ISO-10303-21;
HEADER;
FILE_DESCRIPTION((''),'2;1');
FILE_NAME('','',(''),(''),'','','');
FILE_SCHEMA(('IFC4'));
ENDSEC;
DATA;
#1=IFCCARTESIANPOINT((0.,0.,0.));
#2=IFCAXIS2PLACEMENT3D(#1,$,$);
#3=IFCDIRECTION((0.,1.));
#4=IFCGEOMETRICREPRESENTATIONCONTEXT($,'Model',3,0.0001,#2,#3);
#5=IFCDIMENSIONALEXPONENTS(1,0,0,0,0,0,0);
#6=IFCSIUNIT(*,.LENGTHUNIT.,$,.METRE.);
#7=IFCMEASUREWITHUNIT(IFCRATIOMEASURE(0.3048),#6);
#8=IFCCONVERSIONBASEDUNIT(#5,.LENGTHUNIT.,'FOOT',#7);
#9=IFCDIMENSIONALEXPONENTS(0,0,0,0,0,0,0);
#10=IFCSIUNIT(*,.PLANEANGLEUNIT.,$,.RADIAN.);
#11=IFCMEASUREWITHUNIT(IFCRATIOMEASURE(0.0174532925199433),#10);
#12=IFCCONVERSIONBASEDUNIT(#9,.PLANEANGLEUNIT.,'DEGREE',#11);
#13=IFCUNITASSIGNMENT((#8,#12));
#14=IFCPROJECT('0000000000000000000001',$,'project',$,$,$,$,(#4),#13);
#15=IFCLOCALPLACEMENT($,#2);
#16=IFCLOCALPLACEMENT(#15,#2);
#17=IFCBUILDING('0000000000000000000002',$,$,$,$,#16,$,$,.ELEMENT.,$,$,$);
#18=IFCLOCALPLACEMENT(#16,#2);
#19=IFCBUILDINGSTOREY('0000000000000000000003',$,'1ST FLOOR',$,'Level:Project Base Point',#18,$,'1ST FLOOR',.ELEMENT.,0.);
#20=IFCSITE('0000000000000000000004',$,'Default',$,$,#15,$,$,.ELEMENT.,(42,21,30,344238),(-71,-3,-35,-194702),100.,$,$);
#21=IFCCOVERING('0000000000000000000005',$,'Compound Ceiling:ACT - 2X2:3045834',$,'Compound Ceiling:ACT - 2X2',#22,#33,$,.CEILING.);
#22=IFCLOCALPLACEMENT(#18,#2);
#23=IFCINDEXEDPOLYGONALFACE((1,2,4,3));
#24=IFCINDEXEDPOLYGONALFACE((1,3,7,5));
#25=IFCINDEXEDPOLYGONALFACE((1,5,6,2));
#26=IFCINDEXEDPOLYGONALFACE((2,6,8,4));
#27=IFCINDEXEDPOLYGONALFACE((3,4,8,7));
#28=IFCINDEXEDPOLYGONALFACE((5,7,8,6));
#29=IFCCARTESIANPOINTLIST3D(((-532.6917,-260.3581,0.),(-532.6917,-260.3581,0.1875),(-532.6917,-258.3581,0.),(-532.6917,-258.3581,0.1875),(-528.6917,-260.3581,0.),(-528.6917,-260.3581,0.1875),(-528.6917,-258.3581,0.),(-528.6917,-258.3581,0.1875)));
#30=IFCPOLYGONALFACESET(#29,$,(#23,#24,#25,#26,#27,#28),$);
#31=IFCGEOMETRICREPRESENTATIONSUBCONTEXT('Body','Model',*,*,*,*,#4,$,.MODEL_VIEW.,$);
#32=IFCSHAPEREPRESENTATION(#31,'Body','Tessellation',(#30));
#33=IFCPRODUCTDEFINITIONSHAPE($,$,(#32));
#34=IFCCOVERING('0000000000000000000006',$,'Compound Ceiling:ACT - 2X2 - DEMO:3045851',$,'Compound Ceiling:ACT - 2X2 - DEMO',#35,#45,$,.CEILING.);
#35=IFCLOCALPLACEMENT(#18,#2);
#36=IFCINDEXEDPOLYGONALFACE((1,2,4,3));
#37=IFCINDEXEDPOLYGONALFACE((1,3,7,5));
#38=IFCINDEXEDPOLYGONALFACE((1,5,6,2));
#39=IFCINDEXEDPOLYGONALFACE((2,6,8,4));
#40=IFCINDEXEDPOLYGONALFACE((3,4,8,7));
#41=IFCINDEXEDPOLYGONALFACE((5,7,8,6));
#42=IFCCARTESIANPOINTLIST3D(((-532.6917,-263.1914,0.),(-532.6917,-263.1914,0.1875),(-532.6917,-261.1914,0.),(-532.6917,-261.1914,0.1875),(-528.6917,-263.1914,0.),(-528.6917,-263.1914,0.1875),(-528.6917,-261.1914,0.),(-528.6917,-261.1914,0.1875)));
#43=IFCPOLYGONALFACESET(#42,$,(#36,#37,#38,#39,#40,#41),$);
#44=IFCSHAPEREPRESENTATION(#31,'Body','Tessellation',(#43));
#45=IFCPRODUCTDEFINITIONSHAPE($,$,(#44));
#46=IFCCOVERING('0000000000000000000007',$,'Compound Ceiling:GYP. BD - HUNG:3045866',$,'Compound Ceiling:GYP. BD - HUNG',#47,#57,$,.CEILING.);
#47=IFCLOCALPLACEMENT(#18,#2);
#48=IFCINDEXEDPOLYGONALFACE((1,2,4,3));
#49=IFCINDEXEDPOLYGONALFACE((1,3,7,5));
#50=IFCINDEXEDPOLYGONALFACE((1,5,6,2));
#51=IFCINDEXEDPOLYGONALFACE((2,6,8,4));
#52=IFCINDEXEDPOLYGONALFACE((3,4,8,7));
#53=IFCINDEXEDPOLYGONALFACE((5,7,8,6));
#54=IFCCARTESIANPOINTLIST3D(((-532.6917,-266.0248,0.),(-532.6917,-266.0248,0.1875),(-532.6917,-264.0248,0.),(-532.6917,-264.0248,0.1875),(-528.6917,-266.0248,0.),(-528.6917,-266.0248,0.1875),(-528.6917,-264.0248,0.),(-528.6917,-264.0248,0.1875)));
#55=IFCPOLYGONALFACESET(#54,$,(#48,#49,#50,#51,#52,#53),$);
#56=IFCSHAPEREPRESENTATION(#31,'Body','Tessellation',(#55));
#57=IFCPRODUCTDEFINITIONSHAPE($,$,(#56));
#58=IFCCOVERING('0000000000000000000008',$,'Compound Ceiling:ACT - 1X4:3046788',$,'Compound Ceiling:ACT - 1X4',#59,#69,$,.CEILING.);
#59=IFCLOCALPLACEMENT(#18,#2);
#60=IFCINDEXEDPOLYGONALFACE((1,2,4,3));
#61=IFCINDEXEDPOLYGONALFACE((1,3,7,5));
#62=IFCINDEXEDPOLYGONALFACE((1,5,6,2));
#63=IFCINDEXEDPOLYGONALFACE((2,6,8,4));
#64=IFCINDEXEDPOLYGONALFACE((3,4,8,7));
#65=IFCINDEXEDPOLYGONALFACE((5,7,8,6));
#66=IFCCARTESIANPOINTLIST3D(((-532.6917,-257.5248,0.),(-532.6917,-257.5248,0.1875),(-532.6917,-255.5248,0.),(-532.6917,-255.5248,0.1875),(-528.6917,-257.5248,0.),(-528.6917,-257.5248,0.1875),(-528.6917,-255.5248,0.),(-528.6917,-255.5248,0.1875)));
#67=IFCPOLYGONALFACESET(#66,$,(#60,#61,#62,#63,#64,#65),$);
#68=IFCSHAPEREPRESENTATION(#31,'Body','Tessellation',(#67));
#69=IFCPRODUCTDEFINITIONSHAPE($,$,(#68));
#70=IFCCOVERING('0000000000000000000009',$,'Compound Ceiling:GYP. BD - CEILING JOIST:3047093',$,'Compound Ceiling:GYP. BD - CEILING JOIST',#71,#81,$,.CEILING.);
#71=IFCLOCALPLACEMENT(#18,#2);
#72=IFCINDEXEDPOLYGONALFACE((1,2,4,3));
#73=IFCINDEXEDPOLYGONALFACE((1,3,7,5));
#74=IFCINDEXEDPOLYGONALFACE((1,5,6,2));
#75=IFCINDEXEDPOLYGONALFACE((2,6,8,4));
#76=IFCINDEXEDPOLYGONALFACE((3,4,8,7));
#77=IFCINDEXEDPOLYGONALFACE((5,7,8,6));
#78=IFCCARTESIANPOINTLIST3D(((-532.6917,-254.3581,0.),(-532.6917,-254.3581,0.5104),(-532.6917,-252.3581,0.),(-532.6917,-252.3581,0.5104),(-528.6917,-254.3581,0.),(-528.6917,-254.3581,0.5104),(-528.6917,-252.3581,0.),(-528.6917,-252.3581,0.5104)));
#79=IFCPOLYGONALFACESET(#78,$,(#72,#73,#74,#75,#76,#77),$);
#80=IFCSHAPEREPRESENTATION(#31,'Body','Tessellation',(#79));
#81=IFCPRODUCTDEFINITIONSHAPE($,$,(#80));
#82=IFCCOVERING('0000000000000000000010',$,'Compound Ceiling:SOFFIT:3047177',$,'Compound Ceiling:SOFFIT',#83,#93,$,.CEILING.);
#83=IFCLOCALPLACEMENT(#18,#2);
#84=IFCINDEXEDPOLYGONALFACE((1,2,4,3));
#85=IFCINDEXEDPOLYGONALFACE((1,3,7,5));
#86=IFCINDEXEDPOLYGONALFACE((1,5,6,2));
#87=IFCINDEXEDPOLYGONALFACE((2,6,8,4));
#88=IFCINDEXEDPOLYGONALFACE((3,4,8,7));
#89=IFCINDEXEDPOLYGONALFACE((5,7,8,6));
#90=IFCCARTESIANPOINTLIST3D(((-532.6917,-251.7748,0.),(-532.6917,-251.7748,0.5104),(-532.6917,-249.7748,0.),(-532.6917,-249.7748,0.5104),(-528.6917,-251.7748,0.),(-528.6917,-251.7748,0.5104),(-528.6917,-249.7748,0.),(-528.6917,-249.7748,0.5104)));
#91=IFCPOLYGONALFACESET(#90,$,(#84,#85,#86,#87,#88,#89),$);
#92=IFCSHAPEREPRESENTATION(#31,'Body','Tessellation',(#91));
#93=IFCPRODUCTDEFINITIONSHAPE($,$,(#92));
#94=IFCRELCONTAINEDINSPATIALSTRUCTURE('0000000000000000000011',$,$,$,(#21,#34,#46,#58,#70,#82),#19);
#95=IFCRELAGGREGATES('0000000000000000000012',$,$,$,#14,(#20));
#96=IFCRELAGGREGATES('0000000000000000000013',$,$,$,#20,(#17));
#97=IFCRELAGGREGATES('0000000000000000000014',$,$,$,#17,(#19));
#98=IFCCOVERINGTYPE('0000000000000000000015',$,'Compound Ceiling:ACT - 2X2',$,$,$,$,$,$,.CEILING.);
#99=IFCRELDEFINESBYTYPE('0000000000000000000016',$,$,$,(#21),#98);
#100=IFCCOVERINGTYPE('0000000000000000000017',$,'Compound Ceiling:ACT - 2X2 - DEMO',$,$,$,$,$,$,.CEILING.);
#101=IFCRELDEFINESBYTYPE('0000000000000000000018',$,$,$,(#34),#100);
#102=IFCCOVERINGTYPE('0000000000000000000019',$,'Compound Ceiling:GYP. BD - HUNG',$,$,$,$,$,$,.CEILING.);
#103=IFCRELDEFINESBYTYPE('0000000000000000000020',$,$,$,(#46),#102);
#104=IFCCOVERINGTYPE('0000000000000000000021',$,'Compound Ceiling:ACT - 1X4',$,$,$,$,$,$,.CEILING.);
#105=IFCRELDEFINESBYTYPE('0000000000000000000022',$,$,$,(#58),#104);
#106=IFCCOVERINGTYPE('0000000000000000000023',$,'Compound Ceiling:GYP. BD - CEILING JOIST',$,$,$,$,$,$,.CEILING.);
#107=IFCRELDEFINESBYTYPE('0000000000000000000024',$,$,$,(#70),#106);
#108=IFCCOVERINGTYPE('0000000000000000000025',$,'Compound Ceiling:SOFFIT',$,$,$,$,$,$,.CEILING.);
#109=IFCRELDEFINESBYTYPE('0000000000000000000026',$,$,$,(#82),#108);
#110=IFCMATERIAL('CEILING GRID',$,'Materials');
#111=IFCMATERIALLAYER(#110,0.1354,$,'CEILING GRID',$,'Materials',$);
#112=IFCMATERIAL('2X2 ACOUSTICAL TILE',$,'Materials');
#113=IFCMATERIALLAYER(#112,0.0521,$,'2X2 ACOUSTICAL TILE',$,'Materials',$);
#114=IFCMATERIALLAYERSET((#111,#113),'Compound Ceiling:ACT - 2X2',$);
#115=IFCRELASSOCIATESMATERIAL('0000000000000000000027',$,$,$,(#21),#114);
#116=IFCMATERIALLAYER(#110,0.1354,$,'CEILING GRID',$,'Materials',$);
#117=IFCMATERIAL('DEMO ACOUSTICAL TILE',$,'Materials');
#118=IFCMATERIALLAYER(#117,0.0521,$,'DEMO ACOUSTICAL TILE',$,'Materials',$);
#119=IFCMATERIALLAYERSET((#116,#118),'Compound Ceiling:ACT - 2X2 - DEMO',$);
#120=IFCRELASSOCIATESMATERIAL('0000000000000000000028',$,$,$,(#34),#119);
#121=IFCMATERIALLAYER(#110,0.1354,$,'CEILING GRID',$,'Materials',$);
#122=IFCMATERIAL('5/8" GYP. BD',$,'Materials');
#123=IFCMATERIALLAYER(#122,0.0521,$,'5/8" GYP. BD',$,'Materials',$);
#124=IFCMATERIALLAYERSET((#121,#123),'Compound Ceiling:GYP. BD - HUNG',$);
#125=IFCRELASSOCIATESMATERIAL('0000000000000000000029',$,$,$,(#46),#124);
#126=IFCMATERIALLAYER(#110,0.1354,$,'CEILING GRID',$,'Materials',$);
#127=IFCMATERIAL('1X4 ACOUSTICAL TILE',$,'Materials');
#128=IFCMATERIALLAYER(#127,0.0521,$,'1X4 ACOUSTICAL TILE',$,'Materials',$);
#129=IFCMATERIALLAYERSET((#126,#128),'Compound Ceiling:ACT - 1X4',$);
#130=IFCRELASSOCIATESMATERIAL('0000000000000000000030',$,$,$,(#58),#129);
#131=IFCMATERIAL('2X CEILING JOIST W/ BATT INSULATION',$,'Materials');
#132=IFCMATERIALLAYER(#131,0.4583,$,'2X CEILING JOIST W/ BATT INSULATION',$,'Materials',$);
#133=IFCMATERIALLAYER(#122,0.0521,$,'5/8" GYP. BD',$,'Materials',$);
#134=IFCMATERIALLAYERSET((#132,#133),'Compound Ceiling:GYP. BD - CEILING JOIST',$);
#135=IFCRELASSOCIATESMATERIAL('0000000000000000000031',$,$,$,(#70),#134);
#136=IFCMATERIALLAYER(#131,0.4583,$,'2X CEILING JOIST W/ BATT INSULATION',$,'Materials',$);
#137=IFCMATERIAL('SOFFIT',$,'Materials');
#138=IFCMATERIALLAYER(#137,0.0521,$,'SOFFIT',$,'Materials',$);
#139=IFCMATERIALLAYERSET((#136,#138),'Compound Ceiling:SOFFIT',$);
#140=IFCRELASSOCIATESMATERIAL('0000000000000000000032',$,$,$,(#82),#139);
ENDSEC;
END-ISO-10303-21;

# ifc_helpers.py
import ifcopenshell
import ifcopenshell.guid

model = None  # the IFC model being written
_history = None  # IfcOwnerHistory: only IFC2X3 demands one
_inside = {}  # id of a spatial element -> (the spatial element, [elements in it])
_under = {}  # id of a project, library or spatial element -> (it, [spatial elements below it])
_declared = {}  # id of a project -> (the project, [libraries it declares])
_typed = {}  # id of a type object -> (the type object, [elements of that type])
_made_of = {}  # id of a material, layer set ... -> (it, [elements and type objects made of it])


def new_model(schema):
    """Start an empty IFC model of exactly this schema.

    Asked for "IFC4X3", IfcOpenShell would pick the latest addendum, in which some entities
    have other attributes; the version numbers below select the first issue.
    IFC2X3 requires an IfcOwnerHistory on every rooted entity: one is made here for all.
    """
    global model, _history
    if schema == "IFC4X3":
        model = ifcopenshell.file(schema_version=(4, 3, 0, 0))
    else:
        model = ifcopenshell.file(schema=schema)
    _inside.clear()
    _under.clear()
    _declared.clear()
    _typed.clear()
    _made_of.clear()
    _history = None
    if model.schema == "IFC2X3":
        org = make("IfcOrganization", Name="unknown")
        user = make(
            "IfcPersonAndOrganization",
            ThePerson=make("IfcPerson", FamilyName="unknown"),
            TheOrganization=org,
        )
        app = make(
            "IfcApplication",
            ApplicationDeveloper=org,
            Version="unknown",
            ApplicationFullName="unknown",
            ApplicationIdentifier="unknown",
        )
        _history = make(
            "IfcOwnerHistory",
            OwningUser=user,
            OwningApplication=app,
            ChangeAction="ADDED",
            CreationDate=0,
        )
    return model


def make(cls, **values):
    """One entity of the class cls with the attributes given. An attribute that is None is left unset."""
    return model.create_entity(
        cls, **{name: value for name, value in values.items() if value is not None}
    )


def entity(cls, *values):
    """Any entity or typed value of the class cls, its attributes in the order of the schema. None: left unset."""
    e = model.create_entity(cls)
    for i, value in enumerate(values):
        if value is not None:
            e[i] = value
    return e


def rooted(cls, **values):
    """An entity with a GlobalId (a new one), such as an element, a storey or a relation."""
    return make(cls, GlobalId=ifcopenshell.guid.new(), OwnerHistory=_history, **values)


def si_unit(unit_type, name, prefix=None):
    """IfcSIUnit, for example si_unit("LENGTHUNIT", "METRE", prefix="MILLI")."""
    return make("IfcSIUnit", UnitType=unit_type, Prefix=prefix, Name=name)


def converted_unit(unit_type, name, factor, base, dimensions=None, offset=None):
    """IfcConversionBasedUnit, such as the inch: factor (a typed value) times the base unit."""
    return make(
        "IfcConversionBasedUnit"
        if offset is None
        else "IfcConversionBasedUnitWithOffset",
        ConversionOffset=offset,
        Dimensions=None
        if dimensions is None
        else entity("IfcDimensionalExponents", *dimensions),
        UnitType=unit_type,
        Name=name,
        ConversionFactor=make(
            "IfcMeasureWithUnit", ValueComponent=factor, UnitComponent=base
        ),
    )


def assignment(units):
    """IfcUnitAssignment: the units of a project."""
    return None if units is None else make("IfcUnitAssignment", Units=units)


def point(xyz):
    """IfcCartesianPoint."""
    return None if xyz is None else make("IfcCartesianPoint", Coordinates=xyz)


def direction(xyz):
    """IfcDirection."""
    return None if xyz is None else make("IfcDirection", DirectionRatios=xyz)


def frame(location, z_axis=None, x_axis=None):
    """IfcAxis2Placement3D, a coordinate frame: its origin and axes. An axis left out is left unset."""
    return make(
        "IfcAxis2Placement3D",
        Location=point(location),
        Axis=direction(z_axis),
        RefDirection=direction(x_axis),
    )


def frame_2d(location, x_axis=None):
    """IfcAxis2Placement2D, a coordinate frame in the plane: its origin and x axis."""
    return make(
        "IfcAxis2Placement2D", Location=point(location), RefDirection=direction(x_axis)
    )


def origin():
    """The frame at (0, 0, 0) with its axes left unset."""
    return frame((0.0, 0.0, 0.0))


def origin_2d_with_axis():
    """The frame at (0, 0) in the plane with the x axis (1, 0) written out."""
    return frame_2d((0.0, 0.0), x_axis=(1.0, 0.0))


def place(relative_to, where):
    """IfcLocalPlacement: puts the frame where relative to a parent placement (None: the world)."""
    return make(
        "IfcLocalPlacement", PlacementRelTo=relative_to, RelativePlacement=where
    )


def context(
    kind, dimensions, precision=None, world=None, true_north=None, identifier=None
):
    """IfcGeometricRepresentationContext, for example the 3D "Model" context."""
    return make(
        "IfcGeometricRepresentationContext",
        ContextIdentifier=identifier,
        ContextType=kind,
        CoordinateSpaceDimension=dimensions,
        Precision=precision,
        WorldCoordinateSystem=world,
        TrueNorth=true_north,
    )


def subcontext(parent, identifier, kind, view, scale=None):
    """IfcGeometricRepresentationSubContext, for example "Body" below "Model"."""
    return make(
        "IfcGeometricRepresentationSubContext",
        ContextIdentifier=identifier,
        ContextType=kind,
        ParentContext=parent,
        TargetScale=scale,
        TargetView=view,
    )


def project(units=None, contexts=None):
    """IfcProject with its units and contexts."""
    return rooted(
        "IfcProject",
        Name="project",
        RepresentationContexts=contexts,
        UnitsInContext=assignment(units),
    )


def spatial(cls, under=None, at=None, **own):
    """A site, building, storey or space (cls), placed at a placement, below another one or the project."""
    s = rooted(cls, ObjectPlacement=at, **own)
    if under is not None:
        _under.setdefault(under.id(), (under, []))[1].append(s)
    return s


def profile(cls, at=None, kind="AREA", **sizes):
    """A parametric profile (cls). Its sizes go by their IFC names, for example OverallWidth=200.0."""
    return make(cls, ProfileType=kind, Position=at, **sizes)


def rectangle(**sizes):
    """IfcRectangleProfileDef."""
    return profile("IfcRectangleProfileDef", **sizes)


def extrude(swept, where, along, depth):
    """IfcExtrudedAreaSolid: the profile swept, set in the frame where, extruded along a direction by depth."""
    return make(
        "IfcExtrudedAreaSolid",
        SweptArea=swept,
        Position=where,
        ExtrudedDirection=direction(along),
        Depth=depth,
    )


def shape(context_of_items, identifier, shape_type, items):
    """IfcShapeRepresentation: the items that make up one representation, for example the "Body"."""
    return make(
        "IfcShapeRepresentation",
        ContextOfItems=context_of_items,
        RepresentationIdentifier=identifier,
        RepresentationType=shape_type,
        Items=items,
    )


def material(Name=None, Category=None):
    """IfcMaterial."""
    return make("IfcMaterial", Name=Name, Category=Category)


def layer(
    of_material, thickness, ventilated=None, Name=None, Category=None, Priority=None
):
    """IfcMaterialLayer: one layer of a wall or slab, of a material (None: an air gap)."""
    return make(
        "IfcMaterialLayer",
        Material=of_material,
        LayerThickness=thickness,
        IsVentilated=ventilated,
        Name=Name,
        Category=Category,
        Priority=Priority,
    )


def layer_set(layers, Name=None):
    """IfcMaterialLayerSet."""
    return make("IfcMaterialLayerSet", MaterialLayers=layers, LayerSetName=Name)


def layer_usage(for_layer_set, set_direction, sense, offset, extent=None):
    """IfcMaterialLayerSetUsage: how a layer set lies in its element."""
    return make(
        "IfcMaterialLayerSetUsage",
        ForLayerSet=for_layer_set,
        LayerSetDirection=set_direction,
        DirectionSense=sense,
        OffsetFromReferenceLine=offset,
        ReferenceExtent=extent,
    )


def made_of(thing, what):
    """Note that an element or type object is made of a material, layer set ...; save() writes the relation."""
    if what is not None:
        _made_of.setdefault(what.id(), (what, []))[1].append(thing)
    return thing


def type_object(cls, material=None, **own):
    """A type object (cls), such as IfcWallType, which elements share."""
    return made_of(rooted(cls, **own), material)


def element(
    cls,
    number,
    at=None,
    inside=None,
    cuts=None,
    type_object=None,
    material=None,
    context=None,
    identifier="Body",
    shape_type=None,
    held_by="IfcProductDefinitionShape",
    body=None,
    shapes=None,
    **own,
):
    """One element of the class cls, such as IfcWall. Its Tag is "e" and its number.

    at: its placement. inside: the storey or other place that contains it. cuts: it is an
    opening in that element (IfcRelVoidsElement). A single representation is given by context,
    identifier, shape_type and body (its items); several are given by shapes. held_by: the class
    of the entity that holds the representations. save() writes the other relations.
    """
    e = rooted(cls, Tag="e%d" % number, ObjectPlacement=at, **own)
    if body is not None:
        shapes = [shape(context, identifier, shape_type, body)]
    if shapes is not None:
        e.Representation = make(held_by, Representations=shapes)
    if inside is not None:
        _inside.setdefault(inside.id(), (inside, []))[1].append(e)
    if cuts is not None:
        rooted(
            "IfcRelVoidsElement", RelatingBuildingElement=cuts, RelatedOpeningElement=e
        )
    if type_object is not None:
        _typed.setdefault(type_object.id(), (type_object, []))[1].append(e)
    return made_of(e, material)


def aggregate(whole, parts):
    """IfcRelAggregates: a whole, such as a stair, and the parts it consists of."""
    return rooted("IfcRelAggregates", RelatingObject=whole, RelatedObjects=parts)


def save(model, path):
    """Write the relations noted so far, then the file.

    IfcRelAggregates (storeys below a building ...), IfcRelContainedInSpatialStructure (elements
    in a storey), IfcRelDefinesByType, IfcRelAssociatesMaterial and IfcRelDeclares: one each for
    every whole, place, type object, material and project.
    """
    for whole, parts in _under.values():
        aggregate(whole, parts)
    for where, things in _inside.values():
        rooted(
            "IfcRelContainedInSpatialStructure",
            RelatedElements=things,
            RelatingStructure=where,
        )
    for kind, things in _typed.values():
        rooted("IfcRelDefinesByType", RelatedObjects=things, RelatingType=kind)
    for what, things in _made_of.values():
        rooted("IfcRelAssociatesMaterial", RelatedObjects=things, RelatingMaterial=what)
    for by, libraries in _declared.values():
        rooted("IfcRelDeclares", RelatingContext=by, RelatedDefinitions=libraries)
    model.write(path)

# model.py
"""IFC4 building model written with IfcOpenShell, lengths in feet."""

from ifc_helpers import new_model, entity, si_unit, converted_unit, direction, frame, origin, origin_2d_with_axis, place, context, subcontext, project, spatial, rectangle, extrude, material, layer, layer_set, layer_usage, type_object, element, save


model = new_model("IFC4")

# Units and contexts
model_context = context("Model", 3, precision=0.0001, world=origin(), true_north=direction((0.0, 1.0)))
body_context = subcontext(model_context, "Body", "Model", "MODEL_VIEW")
ifc_project = project(units=[converted_unit("LENGTHUNIT", "FOOT", entity("IfcRatioMeasure", 0.3048), si_unit("LENGTHUNIT", "METRE"), dimensions=[1, 0, 0, 0, 0, 0, 0]), converted_unit("PLANEANGLEUNIT", "DEGREE", entity("IfcRatioMeasure", 0.0174532925199433), si_unit("PLANEANGLEUNIT", "RADIAN"), dimensions=[0, 0, 0, 0, 0, 0, 0])], contexts=[model_context])

# Site, building, storey
site_placement = place(None, origin())
site = spatial("IfcSite", under=ifc_project, at=site_placement, Name="Default", CompositionType="ELEMENT", RefLatitude=(42, 21, 30, 344238), RefLongitude=(-71, -3, -35, -194702), RefElevation=100.0)
building_placement = place(site_placement, origin())
building = spatial("IfcBuilding", under=site, at=building_placement, CompositionType="ELEMENT")
storey_placement = place(building_placement, origin())
storey = spatial("IfcBuildingStorey", under=building, at=storey_placement, Name="1ST FLOOR", ObjectType="Level:Project Base Point", LongName="1ST FLOOR", CompositionType="ELEMENT", Elevation=0.0)

# Coverings
ifc_material_1 = material(Name="CEILING GRID", Category="Materials")
ifc_layer_1 = layer(ifc_material_1, 0.1354, Name="CEILING GRID", Category="Materials")
ifc_material_2 = material(Name="2X2 ACOUSTICAL TILE", Category="Materials")
ifc_layer_2 = layer(ifc_material_2, 0.0521, Name="2X2 ACOUSTICAL TILE", Category="Materials")
ifc_layer_set_1 = layer_set([ifc_layer_1, ifc_layer_2], Name="Compound Ceiling:ACT - 2X2")
ifc_layer_usage_1 = layer_usage(ifc_layer_set_1, "AXIS3", "POSITIVE", 0.0)
covering_type_1 = type_object("IfcCoveringType", Name="Compound Ceiling:ACT - 2X2", PredefinedType="CEILING")
covering_1_placement = place(storey_placement, frame((-532.6917, -260.3581, 0.0)))
element("IfcCovering", 1, at=covering_1_placement, inside=storey, type_object=covering_type_1, material=ifc_layer_usage_1, Name="Compound Ceiling:ACT - 2X2:3045834", ObjectType="Compound Ceiling:ACT - 2X2", PredefinedType="CEILING", context=body_context, shape_type="SweptSolid", body=[
    extrude(rectangle(XDim=4.0, YDim=2.0, at=origin_2d_with_axis()), frame((2.0, 1.0, 0.0), z_axis=(0.0, 0.0, 1.0), x_axis=(-1.0, 0.0, 0.0)), (0.0, 0.0, 1.0), 0.1875),
])
ifc_layer_3 = layer(ifc_material_1, 0.1354, Name="CEILING GRID", Category="Materials")
ifc_material_3 = material(Name="DEMO ACOUSTICAL TILE", Category="Materials")
ifc_layer_4 = layer(ifc_material_3, 0.0521, Name="DEMO ACOUSTICAL TILE", Category="Materials")
ifc_layer_set_2 = layer_set([ifc_layer_3, ifc_layer_4], Name="Compound Ceiling:ACT - 2X2 - DEMO")
ifc_layer_usage_2 = layer_usage(ifc_layer_set_2, "AXIS3", "POSITIVE", 0.0)
covering_type_2 = type_object("IfcCoveringType", Name="Compound Ceiling:ACT - 2X2 - DEMO", PredefinedType="CEILING")
covering_2_placement = place(storey_placement, frame((-532.6917, -263.1914, 0.0)))
element("IfcCovering", 2, at=covering_2_placement, inside=storey, type_object=covering_type_2, material=ifc_layer_usage_2, Name="Compound Ceiling:ACT - 2X2 - DEMO:3045851", ObjectType="Compound Ceiling:ACT - 2X2 - DEMO", PredefinedType="CEILING", context=body_context, shape_type="SweptSolid", body=[
    extrude(rectangle(XDim=4.0, YDim=2.0, at=origin_2d_with_axis()), frame((2.0, 1.0, 0.0), z_axis=(0.0, 0.0, 1.0), x_axis=(-1.0, 0.0, 0.0)), (0.0, 0.0, 1.0), 0.1875),
])
ifc_layer_5 = layer(ifc_material_1, 0.1354, Name="CEILING GRID", Category="Materials")
ifc_material_4 = material(Name="5/8\" GYP. BD", Category="Materials")
ifc_layer_6 = layer(ifc_material_4, 0.0521, Name="5/8\" GYP. BD", Category="Materials")
ifc_layer_set_3 = layer_set([ifc_layer_5, ifc_layer_6], Name="Compound Ceiling:GYP. BD - HUNG")
ifc_layer_usage_3 = layer_usage(ifc_layer_set_3, "AXIS3", "POSITIVE", 0.0)
covering_type_3 = type_object("IfcCoveringType", Name="Compound Ceiling:GYP. BD - HUNG", PredefinedType="CEILING")
covering_3_placement = place(storey_placement, frame((-532.6917, -266.0248, 0.0)))
element("IfcCovering", 3, at=covering_3_placement, inside=storey, type_object=covering_type_3, material=ifc_layer_usage_3, Name="Compound Ceiling:GYP. BD - HUNG:3045866", ObjectType="Compound Ceiling:GYP. BD - HUNG", PredefinedType="CEILING", context=body_context, shape_type="SweptSolid", body=[
    extrude(rectangle(XDim=4.0, YDim=2.0, at=origin_2d_with_axis()), frame((2.0, 1.0, 0.0), z_axis=(0.0, 0.0, 1.0), x_axis=(-1.0, 0.0, 0.0)), (0.0, 0.0, 1.0), 0.1875),
])
ifc_layer_7 = layer(ifc_material_1, 0.1354, Name="CEILING GRID", Category="Materials")
ifc_material_5 = material(Name="1X4 ACOUSTICAL TILE", Category="Materials")
ifc_layer_8 = layer(ifc_material_5, 0.0521, Name="1X4 ACOUSTICAL TILE", Category="Materials")
ifc_layer_set_4 = layer_set([ifc_layer_7, ifc_layer_8], Name="Compound Ceiling:ACT - 1X4")
ifc_layer_usage_4 = layer_usage(ifc_layer_set_4, "AXIS3", "POSITIVE", 0.0)
covering_type_4 = type_object("IfcCoveringType", Name="Compound Ceiling:ACT - 1X4", PredefinedType="CEILING")
covering_4_placement = place(storey_placement, frame((-532.6917, -257.5248, 0.0)))
element("IfcCovering", 4, at=covering_4_placement, inside=storey, type_object=covering_type_4, material=ifc_layer_usage_4, Name="Compound Ceiling:ACT - 1X4:3046788", ObjectType="Compound Ceiling:ACT - 1X4", PredefinedType="CEILING", context=body_context, shape_type="SweptSolid", body=[
    extrude(rectangle(XDim=4.0, YDim=2.0, at=origin_2d_with_axis()), frame((2.0, 1.0, 0.0), z_axis=(0.0, 0.0, 1.0), x_axis=(-1.0, 0.0, 0.0)), (0.0, 0.0, 1.0), 0.1875),
])
ifc_material_6 = material(Name="2X CEILING JOIST W/ BATT INSULATION", Category="Materials")
ifc_layer_9 = layer(ifc_material_6, 0.4583, Name="2X CEILING JOIST W/ BATT INSULATION", Category="Materials")
ifc_layer_10 = layer(ifc_material_4, 0.0521, Name="5/8\" GYP. BD", Category="Materials")
ifc_layer_set_5 = layer_set([ifc_layer_9, ifc_layer_10], Name="Compound Ceiling:GYP. BD - CEILING JOIST")
ifc_layer_usage_5 = layer_usage(ifc_layer_set_5, "AXIS3", "POSITIVE", 0.0)
covering_type_5 = type_object("IfcCoveringType", Name="Compound Ceiling:GYP. BD - CEILING JOIST", PredefinedType="CEILING")
covering_5_placement = place(storey_placement, frame((-532.6917, -254.3581, 0.0)))
element("IfcCovering", 5, at=covering_5_placement, inside=storey, type_object=covering_type_5, material=ifc_layer_usage_5, Name="Compound Ceiling:GYP. BD - CEILING JOIST:3047093", ObjectType="Compound Ceiling:GYP. BD - CEILING JOIST", PredefinedType="CEILING", context=body_context, shape_type="SweptSolid", body=[
    extrude(rectangle(XDim=4.0, YDim=2.0, at=origin_2d_with_axis()), frame((2.0, 1.0, 0.0), z_axis=(0.0, 0.0, 1.0), x_axis=(-1.0, 0.0, 0.0)), (0.0, 0.0, 1.0), 0.5104),
])
ifc_layer_11 = layer(ifc_material_6, 0.4583, Name="2X CEILING JOIST W/ BATT INSULATION", Category="Materials")
ifc_material_7 = material(Name="SOFFIT", Category="Materials")
ifc_layer_12 = layer(ifc_material_7, 0.0521, Name="SOFFIT", Category="Materials")
ifc_layer_set_6 = layer_set([ifc_layer_11, ifc_layer_12], Name="Compound Ceiling:SOFFIT")
ifc_layer_usage_6 = layer_usage(ifc_layer_set_6, "AXIS3", "POSITIVE", 0.0)
covering_type_6 = type_object("IfcCoveringType", Name="Compound Ceiling:SOFFIT", PredefinedType="CEILING")
covering_6_placement = place(storey_placement, frame((-532.6917, -251.7748, 0.0)))
element("IfcCovering", 6, at=covering_6_placement, inside=storey, type_object=covering_type_6, material=ifc_layer_usage_6, Name="Compound Ceiling:SOFFIT:3047177", ObjectType="Compound Ceiling:SOFFIT", PredefinedType="CEILING", context=body_context, shape_type="SweptSolid", body=[
    extrude(rectangle(XDim=4.0, YDim=2.0, at=origin_2d_with_axis()), frame((2.0, 1.0, 0.0), z_axis=(0.0, 0.0, 1.0), x_axis=(-1.0, 0.0, 0.0)), (0.0, 0.0, 1.0), 0.5104),
])

save(model, "model.ifc")
